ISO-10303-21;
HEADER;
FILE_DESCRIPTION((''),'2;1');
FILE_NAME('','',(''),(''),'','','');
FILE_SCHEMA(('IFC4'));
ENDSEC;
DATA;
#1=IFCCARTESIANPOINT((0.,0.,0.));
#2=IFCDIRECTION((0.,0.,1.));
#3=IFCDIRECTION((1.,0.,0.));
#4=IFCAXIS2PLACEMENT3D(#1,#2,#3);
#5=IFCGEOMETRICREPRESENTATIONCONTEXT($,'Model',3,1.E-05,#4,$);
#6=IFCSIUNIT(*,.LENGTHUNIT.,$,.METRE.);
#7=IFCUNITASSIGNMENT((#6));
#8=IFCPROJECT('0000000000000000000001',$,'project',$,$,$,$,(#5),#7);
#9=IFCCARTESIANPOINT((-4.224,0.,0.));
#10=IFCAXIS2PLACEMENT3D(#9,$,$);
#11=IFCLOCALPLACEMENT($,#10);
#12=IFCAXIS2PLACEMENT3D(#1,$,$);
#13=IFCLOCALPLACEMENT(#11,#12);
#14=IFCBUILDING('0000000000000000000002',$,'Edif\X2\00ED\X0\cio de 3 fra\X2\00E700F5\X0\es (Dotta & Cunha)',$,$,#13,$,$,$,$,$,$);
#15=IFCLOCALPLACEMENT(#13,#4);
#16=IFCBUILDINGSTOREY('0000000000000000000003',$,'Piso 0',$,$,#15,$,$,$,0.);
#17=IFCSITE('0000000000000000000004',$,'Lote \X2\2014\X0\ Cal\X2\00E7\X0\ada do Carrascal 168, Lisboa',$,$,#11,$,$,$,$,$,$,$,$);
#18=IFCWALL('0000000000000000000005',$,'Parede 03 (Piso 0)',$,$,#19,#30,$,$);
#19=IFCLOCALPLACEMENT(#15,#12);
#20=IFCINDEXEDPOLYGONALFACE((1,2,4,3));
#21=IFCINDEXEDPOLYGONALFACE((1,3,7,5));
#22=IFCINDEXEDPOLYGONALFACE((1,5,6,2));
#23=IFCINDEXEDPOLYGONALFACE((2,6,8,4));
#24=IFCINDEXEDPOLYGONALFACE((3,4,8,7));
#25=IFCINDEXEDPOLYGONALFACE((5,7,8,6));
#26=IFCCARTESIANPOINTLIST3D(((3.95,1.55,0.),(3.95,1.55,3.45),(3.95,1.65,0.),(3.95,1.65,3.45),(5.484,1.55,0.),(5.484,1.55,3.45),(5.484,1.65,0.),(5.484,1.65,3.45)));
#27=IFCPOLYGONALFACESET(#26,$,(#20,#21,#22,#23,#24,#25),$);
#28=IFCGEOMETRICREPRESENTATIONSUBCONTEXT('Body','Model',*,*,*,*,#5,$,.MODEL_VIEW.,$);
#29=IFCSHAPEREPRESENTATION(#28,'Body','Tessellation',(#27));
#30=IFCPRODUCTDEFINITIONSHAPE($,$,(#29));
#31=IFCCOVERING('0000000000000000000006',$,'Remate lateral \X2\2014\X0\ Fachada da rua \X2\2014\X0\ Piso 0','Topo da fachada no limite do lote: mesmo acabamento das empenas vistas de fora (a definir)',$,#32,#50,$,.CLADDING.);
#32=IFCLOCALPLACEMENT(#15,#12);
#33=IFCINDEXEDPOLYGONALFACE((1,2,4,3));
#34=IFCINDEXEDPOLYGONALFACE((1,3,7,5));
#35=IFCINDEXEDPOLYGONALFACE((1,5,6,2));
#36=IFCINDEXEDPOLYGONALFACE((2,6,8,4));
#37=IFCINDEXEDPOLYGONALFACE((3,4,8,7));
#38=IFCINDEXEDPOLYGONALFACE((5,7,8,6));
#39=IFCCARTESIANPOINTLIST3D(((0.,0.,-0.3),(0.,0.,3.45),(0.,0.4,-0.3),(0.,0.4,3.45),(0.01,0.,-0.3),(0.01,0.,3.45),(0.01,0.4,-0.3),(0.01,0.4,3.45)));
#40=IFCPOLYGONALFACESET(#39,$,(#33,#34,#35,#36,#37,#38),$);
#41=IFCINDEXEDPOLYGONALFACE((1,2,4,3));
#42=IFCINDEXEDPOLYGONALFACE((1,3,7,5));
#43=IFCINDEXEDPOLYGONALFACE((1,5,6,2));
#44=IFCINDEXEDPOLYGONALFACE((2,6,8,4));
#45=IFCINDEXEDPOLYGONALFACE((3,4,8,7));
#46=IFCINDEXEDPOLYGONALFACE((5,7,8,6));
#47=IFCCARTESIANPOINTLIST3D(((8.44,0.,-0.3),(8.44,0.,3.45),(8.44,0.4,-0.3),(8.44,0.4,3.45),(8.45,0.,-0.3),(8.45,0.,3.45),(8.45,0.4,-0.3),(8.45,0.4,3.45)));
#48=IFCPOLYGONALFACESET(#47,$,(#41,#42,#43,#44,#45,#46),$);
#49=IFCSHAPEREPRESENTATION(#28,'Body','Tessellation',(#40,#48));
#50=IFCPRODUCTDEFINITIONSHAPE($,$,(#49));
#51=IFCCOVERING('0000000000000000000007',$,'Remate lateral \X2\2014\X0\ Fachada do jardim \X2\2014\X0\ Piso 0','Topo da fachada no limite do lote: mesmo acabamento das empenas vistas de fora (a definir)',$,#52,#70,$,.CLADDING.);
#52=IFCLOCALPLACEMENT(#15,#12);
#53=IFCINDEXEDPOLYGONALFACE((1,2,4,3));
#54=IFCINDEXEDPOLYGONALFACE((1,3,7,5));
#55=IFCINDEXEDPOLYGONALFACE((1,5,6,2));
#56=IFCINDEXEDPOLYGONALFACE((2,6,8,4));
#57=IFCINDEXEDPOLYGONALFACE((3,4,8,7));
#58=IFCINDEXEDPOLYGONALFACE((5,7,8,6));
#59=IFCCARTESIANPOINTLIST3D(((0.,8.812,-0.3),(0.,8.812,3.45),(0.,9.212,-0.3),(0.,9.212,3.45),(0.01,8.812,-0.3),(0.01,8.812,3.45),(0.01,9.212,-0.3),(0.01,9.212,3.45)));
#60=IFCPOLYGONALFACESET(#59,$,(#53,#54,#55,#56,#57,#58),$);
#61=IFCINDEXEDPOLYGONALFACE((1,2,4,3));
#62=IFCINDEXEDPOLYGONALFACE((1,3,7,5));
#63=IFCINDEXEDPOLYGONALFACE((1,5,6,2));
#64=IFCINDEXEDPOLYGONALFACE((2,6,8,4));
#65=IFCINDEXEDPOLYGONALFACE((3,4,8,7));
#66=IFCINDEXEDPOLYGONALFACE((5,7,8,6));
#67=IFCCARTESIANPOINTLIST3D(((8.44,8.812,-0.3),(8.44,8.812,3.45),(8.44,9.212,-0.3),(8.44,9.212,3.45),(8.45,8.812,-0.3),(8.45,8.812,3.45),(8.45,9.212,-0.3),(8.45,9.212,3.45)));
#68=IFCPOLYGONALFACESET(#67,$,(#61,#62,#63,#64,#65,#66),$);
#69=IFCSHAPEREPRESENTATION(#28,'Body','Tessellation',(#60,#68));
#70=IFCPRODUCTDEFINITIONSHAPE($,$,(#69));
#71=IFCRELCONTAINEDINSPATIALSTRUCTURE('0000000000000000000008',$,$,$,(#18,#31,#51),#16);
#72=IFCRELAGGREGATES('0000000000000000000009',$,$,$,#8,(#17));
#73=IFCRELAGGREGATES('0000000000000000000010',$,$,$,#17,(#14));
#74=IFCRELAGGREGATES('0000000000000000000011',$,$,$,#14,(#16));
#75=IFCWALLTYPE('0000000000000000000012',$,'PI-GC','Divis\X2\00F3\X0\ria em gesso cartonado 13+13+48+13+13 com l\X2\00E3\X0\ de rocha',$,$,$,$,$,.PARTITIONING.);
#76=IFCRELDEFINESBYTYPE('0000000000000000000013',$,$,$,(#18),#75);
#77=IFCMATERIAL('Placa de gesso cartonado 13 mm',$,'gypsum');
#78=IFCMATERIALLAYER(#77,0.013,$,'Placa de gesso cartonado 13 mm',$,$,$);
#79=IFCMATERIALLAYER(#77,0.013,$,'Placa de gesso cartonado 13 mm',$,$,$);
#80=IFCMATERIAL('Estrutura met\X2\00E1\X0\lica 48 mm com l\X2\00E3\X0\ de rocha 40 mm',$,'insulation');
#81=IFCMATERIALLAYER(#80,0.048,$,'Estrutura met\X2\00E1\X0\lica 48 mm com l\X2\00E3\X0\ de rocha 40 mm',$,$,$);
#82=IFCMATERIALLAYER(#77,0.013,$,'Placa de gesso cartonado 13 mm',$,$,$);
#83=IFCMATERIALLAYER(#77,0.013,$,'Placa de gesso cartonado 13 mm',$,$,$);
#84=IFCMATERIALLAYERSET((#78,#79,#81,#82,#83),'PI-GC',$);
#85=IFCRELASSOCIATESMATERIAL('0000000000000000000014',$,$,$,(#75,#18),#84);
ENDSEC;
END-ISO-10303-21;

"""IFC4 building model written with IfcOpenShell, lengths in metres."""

from ifc_helpers import new_model, si_unit, frame, origin, origin_with_axes, place, context, subcontext, project, spatial, line, indexed_curve, outline, extrude, material, layer, layer_set, layer_usage, type_object, element, save


model = new_model("IFC4")

# Units and contexts
model_context = context("Model", 3, precision=1e-05, world=origin_with_axes())
body_context = subcontext(model_context, "Body", "Model", "MODEL_VIEW")
ifc_project = project(units=[si_unit("LENGTHUNIT", "METRE")], contexts=[model_context])

# Site, building, storey
site_placement = place(None, frame((-4.224, 0.0, 0.0)))
site = spatial("IfcSite", under=ifc_project, at=site_placement, Name="Lote — Calçada do Carrascal 168, Lisboa")
building_placement = place(site_placement, origin())
building = spatial("IfcBuilding", under=site, at=building_placement, Name="Edifício de 3 frações (Dotta & Cunha)")
storey_placement = place(building_placement, origin_with_axes())
storey = spatial("IfcBuildingStorey", under=building, at=storey_placement, Name="Piso 0", Elevation=0.0)

# Wall
ifc_material_1 = material(Name="Placa de gesso cartonado 13 mm", Category="gypsum")
ifc_layer_1 = layer(ifc_material_1, 0.013, Name="Placa de gesso cartonado 13 mm")
ifc_layer_2 = layer(ifc_material_1, 0.013, Name="Placa de gesso cartonado 13 mm")
ifc_material_2 = material(Name="Estrutura metálica 48 mm com lã de rocha 40 mm", Category="insulation")
ifc_layer_3 = layer(ifc_material_2, 0.048, Name="Estrutura metálica 48 mm com lã de rocha 40 mm")
ifc_layer_4 = layer(ifc_material_1, 0.013, Name="Placa de gesso cartonado 13 mm")
ifc_layer_5 = layer(ifc_material_1, 0.013, Name="Placa de gesso cartonado 13 mm")
ifc_layer_set_1 = layer_set([ifc_layer_1, ifc_layer_2, ifc_layer_3, ifc_layer_4, ifc_layer_5], Name="PI-GC")
ifc_layer_usage_1 = layer_usage(ifc_layer_set_1, "AXIS2", "POSITIVE", 0.0)
wall_type_1 = type_object("IfcWallType", Name="PI-GC", Description="Divisória em gesso cartonado 13+13+48+13+13 com lã de rocha", PredefinedType="PARTITIONING", material=ifc_layer_set_1)
wall_1_placement = place(storey_placement, origin_with_axes())
element("IfcWall", 1, at=wall_1_placement, inside=storey, type_object=wall_type_1, material=ifc_layer_usage_1, Name="Parede 03 (Piso 0)", context=body_context, shape_type="SweptSolid", body=[
    extrude(outline(indexed_curve([(5.484, 1.55), (5.484, 1.65), (3.95, 1.65), (3.95, 1.55)], segments=[line(1, 2, 3, 4, 1)])), origin_with_axes(), (0.0, 0.0, 1.0), 3.45),
])

# Coverings
covering_1_placement = place(storey_placement, frame((0.0, 0.0, -0.3), z_axis=(0.0, 0.0, 1.0), x_axis=(1.0, 0.0, 0.0)))
element("IfcCovering", 2, at=covering_1_placement, inside=storey, Name="Remate lateral — Fachada da rua — Piso 0", Description="Topo da fachada no limite do lote: mesmo acabamento das empenas vistas de fora (a definir)", PredefinedType="CLADDING", context=body_context, shape_type="SweptSolid", body=[
    extrude(outline(indexed_curve([(0.0, 0.0), (0.0, 0.4), (0.01, 0.4), (0.01, 0.0)], segments=[line(1, 2, 3, 4, 1)])), origin_with_axes(), (0.0, 0.0, 1.0), 3.75),
    extrude(outline(indexed_curve([(8.44, 0.0), (8.44, 0.4), (8.45, 0.4), (8.45, 0.0)], segments=[line(1, 2, 3, 4, 1)])), origin_with_axes(), (0.0, 0.0, 1.0), 3.75),
])
covering_2_placement = place(storey_placement, frame((0.0, 0.0, -0.3), z_axis=(0.0, 0.0, 1.0), x_axis=(1.0, 0.0, 0.0)))
element("IfcCovering", 3, at=covering_2_placement, inside=storey, Name="Remate lateral — Fachada do jardim — Piso 0", Description="Topo da fachada no limite do lote: mesmo acabamento das empenas vistas de fora (a definir)", PredefinedType="CLADDING", context=body_context, shape_type="SweptSolid", body=[
    extrude(outline(indexed_curve([(0.0, 8.812), (0.0, 9.212), (0.01, 9.212), (0.01, 8.812)], segments=[line(1, 2, 3, 4, 1)])), origin_with_axes(), (0.0, 0.0, 1.0), 3.75),
    extrude(outline(indexed_curve([(8.44, 8.812), (8.44, 9.212), (8.45, 9.212), (8.45, 8.812)], segments=[line(1, 2, 3, 4, 1)])), origin_with_axes(), (0.0, 0.0, 1.0), 3.75),
])

save(model, "model.ifc")
